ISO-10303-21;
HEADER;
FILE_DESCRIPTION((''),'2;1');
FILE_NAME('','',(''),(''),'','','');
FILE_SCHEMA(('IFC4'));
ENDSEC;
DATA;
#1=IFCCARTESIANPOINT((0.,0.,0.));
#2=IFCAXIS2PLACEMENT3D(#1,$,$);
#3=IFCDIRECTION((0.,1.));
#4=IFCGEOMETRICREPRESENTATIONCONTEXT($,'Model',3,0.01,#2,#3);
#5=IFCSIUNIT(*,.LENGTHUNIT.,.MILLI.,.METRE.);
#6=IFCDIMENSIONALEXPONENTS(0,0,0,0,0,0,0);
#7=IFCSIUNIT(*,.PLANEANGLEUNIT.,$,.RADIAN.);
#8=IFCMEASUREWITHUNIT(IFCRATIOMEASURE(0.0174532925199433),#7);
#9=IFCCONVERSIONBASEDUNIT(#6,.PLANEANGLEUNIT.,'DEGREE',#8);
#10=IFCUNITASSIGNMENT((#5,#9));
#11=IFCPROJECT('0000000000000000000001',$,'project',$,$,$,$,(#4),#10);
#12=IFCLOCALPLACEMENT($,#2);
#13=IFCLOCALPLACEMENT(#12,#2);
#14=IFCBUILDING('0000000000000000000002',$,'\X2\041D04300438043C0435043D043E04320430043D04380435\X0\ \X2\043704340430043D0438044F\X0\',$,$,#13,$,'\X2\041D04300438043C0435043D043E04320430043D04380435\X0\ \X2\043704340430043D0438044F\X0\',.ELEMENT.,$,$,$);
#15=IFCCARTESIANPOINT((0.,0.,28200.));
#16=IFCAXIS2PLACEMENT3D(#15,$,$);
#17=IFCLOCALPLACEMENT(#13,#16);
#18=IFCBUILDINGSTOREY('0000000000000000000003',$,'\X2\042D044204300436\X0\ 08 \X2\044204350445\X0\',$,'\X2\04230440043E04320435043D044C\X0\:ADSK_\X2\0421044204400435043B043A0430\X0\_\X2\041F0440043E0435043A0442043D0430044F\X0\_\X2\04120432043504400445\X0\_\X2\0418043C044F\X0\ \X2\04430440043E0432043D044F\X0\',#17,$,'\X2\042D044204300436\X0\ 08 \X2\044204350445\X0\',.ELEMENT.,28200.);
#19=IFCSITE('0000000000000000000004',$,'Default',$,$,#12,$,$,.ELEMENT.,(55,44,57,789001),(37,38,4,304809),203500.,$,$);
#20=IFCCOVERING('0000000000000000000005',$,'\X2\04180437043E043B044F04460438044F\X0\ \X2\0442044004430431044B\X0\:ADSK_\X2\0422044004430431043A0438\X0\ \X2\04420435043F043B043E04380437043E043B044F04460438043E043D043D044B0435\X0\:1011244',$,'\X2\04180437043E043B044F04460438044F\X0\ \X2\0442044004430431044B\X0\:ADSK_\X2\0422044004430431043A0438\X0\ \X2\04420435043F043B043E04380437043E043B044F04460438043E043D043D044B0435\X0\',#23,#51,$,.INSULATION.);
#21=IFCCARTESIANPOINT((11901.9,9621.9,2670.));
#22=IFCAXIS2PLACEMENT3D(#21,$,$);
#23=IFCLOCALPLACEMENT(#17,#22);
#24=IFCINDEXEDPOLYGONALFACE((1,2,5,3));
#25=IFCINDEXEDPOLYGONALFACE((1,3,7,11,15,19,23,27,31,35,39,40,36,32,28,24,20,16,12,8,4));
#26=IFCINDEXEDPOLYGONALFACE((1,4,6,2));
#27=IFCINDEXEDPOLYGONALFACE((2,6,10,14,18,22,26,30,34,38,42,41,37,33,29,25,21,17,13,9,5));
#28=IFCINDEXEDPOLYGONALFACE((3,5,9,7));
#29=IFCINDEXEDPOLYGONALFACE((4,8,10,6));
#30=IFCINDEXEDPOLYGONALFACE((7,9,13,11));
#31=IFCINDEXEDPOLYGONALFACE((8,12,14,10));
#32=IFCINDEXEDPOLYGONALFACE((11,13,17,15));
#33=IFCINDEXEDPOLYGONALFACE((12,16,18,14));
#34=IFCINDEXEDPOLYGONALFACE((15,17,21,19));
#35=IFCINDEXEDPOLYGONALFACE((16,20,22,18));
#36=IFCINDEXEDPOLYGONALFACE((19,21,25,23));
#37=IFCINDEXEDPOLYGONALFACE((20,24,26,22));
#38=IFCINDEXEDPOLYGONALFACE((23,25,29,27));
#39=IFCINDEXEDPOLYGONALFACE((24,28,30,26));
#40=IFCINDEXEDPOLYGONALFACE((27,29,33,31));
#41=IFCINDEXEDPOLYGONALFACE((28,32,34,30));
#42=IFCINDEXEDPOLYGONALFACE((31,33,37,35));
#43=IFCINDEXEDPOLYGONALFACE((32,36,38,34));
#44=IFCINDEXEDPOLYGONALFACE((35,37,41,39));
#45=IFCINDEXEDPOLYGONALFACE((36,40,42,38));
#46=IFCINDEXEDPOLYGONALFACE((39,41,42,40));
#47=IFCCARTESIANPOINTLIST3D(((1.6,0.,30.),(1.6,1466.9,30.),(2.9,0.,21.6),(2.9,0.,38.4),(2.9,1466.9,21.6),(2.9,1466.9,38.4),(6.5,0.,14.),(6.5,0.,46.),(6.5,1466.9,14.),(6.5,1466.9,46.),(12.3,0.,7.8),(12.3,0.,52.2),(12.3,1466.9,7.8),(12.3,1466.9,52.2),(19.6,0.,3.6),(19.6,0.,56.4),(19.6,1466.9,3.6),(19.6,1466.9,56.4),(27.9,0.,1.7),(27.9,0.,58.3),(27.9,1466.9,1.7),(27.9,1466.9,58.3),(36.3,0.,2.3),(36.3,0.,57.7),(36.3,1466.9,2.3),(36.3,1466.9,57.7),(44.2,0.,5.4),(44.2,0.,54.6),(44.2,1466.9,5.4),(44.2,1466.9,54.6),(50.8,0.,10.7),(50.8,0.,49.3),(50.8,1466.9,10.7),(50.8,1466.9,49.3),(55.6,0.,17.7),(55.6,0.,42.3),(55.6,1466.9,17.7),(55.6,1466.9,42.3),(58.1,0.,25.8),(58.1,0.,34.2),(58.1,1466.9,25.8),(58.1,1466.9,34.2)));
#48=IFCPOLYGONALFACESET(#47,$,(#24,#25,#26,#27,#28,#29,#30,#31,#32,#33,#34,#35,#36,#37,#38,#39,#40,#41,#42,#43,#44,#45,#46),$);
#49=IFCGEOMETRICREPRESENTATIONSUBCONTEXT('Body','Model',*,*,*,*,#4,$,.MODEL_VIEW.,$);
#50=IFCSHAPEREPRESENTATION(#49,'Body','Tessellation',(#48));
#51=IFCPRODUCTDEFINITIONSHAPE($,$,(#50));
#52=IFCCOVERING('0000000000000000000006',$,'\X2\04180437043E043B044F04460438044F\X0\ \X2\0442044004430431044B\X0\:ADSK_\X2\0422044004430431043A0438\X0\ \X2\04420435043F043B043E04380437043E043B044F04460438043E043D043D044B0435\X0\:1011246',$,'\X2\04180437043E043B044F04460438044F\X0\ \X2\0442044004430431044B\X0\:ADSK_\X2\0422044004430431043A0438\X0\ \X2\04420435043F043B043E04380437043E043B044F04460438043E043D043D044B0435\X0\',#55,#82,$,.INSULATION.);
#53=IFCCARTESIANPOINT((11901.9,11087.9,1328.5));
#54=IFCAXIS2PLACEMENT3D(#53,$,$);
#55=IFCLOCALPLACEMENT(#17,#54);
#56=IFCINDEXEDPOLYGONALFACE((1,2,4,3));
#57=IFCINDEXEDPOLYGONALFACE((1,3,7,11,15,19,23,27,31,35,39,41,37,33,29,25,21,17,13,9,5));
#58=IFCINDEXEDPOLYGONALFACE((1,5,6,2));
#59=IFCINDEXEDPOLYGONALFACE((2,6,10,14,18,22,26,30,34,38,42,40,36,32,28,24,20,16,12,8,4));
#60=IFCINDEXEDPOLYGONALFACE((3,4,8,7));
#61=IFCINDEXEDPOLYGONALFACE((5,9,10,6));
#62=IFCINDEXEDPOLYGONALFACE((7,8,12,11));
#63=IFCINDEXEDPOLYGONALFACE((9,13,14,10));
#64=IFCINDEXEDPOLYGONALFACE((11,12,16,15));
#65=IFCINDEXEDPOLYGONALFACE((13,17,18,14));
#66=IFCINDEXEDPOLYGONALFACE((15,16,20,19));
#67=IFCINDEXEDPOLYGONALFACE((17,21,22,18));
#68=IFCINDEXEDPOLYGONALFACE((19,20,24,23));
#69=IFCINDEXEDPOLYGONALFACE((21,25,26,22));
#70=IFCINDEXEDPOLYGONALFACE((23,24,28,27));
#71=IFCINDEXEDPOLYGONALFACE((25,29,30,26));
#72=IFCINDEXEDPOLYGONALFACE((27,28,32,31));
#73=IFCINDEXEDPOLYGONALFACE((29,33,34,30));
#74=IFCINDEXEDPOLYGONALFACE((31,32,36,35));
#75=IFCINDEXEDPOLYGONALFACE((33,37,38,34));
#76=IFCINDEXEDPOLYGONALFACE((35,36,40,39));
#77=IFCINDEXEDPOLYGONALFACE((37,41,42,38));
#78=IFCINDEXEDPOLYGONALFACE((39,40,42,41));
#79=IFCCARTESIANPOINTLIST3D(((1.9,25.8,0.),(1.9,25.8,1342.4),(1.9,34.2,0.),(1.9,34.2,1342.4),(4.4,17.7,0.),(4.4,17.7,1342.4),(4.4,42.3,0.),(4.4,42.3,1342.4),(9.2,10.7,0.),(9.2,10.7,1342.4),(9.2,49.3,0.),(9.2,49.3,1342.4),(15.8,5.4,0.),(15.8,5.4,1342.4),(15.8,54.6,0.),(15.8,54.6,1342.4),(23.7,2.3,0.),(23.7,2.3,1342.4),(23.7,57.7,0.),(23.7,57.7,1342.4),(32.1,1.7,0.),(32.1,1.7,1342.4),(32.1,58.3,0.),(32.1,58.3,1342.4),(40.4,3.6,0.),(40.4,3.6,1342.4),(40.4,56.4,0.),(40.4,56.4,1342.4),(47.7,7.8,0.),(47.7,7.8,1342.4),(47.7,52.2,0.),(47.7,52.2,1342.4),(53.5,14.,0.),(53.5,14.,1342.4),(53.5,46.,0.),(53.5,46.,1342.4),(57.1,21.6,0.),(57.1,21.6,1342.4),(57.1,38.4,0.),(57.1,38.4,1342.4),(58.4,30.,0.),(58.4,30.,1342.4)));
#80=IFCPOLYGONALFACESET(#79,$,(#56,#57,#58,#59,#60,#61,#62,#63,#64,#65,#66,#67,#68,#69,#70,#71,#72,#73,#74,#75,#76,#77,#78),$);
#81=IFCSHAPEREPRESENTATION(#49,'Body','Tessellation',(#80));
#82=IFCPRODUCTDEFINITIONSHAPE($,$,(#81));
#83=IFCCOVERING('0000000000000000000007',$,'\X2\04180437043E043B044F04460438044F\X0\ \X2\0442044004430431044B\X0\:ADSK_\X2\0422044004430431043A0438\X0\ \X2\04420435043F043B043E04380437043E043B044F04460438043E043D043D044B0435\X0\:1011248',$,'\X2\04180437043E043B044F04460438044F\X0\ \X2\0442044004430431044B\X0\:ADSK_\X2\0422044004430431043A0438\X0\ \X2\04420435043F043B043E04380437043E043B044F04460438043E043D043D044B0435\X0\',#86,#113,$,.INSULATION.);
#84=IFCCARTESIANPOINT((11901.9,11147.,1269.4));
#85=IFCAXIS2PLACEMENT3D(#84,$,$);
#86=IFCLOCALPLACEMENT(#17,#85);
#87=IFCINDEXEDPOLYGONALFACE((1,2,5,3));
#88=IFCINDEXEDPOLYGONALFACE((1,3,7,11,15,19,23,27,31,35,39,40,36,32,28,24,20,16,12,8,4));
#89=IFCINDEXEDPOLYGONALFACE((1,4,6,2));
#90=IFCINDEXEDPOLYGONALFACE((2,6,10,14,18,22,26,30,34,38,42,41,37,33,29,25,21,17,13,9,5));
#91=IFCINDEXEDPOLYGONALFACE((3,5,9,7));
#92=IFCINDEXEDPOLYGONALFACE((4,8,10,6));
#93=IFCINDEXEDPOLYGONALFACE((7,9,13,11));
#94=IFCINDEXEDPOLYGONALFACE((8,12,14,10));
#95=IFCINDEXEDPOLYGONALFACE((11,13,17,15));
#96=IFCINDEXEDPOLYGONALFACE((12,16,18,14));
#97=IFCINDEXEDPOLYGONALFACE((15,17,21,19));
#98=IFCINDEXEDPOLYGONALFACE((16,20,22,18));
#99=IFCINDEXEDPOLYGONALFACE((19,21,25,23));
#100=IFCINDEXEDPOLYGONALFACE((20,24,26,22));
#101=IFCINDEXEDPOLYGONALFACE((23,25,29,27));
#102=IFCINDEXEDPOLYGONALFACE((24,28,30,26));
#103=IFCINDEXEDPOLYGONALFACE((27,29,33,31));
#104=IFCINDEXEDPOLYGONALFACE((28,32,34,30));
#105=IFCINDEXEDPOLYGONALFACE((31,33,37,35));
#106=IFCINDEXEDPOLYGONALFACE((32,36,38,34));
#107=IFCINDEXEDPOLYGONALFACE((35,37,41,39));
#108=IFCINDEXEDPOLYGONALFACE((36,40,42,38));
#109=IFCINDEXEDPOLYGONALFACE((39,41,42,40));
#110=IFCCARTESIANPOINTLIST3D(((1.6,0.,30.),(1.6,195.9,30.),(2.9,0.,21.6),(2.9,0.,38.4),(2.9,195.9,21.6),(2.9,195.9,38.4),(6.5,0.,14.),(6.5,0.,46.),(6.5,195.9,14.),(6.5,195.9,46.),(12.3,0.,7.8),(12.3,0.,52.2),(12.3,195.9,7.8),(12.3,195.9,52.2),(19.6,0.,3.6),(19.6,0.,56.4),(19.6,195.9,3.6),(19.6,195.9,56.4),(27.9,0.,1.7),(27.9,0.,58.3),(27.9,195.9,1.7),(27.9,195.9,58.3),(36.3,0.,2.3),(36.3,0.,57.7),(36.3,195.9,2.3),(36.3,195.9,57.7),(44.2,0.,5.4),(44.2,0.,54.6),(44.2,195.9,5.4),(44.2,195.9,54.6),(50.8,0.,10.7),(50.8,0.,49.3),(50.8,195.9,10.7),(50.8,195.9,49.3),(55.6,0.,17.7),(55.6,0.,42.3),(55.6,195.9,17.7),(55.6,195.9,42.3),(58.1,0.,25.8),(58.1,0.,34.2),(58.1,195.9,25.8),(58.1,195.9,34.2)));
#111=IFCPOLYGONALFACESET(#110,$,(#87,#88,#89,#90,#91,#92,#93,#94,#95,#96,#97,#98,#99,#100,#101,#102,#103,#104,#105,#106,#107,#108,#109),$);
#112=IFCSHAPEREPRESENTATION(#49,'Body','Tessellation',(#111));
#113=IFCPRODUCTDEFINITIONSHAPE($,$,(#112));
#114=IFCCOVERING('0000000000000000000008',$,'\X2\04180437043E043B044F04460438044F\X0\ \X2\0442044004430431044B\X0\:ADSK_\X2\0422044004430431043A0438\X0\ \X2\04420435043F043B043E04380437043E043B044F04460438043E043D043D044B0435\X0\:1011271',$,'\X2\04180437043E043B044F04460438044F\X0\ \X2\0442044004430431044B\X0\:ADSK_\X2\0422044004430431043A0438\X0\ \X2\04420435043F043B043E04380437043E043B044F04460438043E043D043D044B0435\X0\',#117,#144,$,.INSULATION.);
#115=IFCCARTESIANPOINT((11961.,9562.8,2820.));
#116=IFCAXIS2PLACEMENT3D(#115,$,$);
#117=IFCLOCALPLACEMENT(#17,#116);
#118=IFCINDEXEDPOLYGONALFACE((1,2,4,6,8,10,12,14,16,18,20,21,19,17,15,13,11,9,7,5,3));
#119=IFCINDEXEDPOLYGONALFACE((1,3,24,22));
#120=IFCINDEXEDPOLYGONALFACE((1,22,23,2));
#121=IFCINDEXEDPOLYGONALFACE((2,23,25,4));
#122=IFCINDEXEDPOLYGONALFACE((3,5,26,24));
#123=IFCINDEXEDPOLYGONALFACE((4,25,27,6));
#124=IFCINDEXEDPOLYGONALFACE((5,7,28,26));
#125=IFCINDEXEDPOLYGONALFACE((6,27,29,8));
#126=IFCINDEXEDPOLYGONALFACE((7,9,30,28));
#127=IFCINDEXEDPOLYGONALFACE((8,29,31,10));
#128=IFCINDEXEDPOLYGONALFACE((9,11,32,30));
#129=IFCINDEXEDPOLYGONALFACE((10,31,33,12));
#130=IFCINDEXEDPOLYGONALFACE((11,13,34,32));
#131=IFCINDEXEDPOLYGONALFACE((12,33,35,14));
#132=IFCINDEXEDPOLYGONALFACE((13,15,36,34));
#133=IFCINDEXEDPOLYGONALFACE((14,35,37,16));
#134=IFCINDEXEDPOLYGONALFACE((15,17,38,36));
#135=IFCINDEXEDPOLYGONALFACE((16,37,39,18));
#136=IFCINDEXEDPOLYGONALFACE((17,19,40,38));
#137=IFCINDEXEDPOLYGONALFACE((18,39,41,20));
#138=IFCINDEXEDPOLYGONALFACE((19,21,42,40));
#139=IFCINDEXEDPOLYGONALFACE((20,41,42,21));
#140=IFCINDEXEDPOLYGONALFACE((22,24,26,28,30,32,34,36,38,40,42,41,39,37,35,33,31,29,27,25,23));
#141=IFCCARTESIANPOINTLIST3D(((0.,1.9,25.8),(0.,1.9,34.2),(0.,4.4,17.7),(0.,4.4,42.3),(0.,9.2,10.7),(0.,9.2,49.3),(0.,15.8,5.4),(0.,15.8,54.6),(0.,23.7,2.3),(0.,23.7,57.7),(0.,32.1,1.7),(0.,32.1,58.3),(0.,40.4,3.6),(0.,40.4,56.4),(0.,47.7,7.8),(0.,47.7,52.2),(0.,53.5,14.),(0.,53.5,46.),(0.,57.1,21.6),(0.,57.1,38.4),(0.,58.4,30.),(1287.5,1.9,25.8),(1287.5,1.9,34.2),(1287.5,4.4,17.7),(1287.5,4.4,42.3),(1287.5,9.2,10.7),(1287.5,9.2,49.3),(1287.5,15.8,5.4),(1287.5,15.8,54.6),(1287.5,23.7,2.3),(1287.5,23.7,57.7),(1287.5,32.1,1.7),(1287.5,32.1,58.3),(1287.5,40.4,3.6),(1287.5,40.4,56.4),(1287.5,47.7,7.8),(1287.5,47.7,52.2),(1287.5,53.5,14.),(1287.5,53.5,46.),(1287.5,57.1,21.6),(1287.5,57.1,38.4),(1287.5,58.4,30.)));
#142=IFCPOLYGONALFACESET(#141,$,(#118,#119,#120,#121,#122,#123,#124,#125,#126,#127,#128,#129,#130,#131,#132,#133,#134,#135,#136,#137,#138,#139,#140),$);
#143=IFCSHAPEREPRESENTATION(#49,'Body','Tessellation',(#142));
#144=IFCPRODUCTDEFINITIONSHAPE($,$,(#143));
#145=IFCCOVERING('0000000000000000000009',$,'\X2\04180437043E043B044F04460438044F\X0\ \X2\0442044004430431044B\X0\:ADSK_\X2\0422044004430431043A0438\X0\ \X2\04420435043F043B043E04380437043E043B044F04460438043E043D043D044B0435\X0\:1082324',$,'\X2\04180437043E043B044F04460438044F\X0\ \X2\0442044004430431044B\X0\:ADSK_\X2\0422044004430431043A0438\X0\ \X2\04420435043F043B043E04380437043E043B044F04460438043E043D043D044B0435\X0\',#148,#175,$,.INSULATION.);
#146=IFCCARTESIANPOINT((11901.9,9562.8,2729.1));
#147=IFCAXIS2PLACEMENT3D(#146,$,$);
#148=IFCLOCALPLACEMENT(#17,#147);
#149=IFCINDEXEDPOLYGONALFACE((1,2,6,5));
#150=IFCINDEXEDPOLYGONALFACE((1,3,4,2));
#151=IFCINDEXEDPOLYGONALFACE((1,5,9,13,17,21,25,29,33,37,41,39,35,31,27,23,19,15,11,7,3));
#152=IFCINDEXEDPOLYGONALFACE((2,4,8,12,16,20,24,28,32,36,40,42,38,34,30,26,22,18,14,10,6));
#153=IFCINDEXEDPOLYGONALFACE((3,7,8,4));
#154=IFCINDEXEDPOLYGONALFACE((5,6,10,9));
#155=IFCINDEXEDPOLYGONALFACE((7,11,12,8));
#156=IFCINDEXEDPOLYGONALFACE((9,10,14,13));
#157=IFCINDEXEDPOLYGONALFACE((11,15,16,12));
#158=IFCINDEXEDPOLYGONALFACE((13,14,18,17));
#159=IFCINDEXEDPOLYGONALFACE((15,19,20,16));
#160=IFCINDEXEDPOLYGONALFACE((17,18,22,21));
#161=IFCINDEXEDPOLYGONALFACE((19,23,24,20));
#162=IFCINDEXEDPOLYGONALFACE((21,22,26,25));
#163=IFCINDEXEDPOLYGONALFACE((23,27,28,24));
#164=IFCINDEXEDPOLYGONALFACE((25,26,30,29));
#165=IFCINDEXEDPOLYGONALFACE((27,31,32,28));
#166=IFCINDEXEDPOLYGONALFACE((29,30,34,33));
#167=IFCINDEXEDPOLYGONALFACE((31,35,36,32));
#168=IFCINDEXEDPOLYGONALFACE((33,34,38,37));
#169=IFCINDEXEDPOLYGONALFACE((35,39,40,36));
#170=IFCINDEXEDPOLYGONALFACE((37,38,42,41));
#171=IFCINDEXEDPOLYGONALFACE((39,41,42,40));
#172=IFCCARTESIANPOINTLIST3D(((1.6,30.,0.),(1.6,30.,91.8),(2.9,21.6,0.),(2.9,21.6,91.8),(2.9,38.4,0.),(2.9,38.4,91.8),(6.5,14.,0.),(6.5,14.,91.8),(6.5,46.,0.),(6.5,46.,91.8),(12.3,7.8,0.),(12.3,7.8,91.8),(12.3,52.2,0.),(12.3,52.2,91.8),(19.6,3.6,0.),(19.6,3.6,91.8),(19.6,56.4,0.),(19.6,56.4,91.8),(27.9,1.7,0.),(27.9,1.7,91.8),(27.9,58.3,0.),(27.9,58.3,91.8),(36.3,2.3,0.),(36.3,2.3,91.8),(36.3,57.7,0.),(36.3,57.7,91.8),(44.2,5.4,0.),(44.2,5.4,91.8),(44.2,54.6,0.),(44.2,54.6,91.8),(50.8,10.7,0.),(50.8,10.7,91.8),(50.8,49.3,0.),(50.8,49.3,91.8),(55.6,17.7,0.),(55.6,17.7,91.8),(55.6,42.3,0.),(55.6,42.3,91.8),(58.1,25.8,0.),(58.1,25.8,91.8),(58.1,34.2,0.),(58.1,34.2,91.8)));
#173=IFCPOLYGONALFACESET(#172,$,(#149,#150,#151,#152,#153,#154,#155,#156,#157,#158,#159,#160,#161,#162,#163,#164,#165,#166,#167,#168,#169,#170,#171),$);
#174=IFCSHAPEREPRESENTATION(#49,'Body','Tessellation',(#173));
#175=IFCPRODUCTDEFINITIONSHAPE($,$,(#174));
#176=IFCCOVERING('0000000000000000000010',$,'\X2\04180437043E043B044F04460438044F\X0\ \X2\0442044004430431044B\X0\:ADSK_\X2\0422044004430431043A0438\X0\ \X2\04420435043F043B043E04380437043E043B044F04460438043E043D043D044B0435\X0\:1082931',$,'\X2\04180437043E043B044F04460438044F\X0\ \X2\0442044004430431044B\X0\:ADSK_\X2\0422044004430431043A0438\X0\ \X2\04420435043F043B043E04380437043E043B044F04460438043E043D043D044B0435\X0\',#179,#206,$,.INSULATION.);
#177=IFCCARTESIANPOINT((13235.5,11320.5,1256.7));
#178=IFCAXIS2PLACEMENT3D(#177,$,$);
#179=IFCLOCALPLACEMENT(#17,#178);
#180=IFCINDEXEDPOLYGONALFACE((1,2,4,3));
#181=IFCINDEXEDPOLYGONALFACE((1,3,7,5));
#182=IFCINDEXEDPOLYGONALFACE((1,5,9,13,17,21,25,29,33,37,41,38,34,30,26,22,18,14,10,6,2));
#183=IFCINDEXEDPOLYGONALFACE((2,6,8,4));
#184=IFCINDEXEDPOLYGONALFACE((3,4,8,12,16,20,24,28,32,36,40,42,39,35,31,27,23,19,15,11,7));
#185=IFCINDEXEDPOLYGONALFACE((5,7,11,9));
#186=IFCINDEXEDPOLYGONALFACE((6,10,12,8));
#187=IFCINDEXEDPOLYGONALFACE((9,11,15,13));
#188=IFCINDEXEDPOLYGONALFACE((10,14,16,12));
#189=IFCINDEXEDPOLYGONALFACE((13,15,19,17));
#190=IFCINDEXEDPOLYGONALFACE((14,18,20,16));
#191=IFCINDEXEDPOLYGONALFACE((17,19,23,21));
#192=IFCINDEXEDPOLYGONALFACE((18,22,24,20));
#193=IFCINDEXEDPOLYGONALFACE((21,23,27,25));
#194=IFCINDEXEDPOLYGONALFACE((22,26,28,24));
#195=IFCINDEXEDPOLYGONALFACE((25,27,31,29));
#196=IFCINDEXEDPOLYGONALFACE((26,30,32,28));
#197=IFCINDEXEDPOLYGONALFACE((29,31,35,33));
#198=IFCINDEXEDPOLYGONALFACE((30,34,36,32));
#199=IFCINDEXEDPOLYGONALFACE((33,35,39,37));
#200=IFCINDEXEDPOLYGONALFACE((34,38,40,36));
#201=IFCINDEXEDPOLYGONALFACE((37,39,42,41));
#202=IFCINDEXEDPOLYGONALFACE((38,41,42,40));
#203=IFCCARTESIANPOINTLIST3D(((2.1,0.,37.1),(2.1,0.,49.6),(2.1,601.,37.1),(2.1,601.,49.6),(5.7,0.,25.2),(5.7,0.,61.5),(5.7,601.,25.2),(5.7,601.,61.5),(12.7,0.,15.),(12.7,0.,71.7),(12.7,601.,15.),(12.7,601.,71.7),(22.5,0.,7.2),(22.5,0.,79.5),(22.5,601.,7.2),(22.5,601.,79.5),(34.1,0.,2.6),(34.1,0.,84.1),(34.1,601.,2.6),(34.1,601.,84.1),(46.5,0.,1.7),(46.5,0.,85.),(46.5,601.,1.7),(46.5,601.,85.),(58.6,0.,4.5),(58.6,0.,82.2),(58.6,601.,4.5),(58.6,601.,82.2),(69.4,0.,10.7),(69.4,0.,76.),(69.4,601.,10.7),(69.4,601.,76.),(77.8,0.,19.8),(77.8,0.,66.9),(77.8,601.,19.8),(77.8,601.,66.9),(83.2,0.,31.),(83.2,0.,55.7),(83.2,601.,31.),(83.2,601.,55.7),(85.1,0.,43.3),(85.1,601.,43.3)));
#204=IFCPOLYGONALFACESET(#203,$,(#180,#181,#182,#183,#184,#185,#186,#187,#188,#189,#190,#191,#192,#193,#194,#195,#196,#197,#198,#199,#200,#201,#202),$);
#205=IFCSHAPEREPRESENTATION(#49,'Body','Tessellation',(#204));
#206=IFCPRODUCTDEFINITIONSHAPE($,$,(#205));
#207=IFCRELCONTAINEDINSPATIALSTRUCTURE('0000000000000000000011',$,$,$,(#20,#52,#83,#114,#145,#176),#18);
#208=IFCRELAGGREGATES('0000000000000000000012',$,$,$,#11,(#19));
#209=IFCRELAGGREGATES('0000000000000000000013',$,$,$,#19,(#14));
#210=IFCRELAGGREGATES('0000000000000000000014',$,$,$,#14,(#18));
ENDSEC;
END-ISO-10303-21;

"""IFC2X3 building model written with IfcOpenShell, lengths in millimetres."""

from ifc_helpers import new_model, entity, si_unit, converted_unit, direction, frame, origin, origin_2d_with_axis, place, context, subcontext, project, spatial, circle, extrude, element, save


model = new_model("IFC2X3")

# Units and contexts
model_context = context("Model", 3, precision=0.01, world=origin(), true_north=direction((0.0, 1.0)))
body_context = subcontext(model_context, "Body", "Model", "MODEL_VIEW")
ifc_project = project(units=[si_unit("LENGTHUNIT", "METRE", prefix="MILLI"), converted_unit("PLANEANGLEUNIT", "DEGREE", entity("IfcRatioMeasure", 0.0174532925199433), si_unit("PLANEANGLEUNIT", "RADIAN"), dimensions=[0, 0, 0, 0, 0, 0, 0])], contexts=[model_context])

# Site, building, storey
site_placement = place(None, origin())
site = spatial("IfcSite", under=ifc_project, at=site_placement, Name="Default", CompositionType="ELEMENT", RefLatitude=(55, 44, 57, 789001), RefLongitude=(37, 38, 4, 304809), RefElevation=203500.0)
building_placement = place(site_placement, origin())
building = spatial("IfcBuilding", under=site, at=building_placement, Name="Наименование здания", LongName="Наименование здания", CompositionType="ELEMENT")
storey_placement = place(building_placement, frame((0.0, 0.0, 28200.0)))
storey = spatial("IfcBuildingStorey", under=building, at=storey_placement, Name="Этаж 08 тех", ObjectType="Уровень:ADSK_Стрелка_Проектная_Вверх_Имя уровня", LongName="Этаж 08 тех", CompositionType="ELEMENT", Elevation=28200.0)

# Coverings
covering_1_placement = place(storey_placement, frame((11901.9, 9621.9, 2670.0)))
element("IfcCovering", 1, at=covering_1_placement, inside=storey, Name="Изоляция трубы:ADSK_Трубки теплоизоляционные:1011244", ObjectType="Изоляция трубы:ADSK_Трубки теплоизоляционные", PredefinedType="INSULATION", context=body_context, shape_type="SweptSolid", body=[
    extrude(circle(Radius=28.4, at=origin_2d_with_axis()), frame((30.0, 0.0, 30.0), z_axis=(0.0, 1.0, 0.0), x_axis=(-1.0, 0.0, 0.0)), (0.0, 0.0, 1.0), 1466.9),
])
covering_2_placement = place(storey_placement, frame((11901.9, 11087.9, 1328.5)))
element("IfcCovering", 2, at=covering_2_placement, inside=storey, Name="Изоляция трубы:ADSK_Трубки теплоизоляционные:1011246", ObjectType="Изоляция трубы:ADSK_Трубки теплоизоляционные", PredefinedType="INSULATION", context=body_context, shape_type="SweptSolid", body=[
    extrude(circle(Radius=28.4, at=origin_2d_with_axis()), frame((30.0, 30.0, 0.0)), (0.0, 0.0, 1.0), 1342.4),
])
covering_3_placement = place(storey_placement, frame((11901.9, 11147.0, 1269.4)))
element("IfcCovering", 3, at=covering_3_placement, inside=storey, Name="Изоляция трубы:ADSK_Трубки теплоизоляционные:1011248", ObjectType="Изоляция трубы:ADSK_Трубки теплоизоляционные", PredefinedType="INSULATION", context=body_context, shape_type="SweptSolid", body=[
    extrude(circle(Radius=28.4, at=origin_2d_with_axis()), frame((30.0, 0.0, 30.0), z_axis=(0.0, 1.0, 0.0), x_axis=(-1.0, 0.0, 0.0)), (0.0, 0.0, 1.0), 195.9),
])
covering_4_placement = place(storey_placement, frame((11961.0, 9562.8, 2820.0)))
element("IfcCovering", 4, at=covering_4_placement, inside=storey, Name="Изоляция трубы:ADSK_Трубки теплоизоляционные:1011271", ObjectType="Изоляция трубы:ADSK_Трубки теплоизоляционные", PredefinedType="INSULATION", context=body_context, shape_type="SweptSolid", body=[
    extrude(circle(Radius=28.4, at=origin_2d_with_axis()), frame((0.0, 30.0, 30.0), z_axis=(1.0, 0.0, 0.0), x_axis=(0.0, 1.0, 0.0)), (0.0, 0.0, 1.0), 1287.5),
])
covering_5_placement = place(storey_placement, frame((11901.9, 9562.8, 2729.1)))
element("IfcCovering", 5, at=covering_5_placement, inside=storey, Name="Изоляция трубы:ADSK_Трубки теплоизоляционные:1082324", ObjectType="Изоляция трубы:ADSK_Трубки теплоизоляционные", PredefinedType="INSULATION", context=body_context, shape_type="SweptSolid", body=[
    extrude(circle(Radius=28.4, at=origin_2d_with_axis()), frame((30.0, 30.0, 0.0), z_axis=(0.0, 0.0, 1.0), x_axis=(-1.0, 0.0, 0.0)), (0.0, 0.0, 1.0), 91.8),
])
covering_6_placement = place(storey_placement, frame((13235.5, 11320.5, 1256.7)))
element("IfcCovering", 6, at=covering_6_placement, inside=storey, Name="Изоляция трубы:ADSK_Трубки теплоизоляционные:1082931", ObjectType="Изоляция трубы:ADSK_Трубки теплоизоляционные", PredefinedType="INSULATION", context=body_context, shape_type="SweptSolid", body=[
    extrude(circle(Radius=41.8, at=origin_2d_with_axis()), frame((43.4, 0.0, 43.4), z_axis=(0.0, 1.0, 0.0), x_axis=(1.0, 0.0, 0.0)), (0.0, 0.0, 1.0), 601.0),
])

save(model, "model.ifc")
